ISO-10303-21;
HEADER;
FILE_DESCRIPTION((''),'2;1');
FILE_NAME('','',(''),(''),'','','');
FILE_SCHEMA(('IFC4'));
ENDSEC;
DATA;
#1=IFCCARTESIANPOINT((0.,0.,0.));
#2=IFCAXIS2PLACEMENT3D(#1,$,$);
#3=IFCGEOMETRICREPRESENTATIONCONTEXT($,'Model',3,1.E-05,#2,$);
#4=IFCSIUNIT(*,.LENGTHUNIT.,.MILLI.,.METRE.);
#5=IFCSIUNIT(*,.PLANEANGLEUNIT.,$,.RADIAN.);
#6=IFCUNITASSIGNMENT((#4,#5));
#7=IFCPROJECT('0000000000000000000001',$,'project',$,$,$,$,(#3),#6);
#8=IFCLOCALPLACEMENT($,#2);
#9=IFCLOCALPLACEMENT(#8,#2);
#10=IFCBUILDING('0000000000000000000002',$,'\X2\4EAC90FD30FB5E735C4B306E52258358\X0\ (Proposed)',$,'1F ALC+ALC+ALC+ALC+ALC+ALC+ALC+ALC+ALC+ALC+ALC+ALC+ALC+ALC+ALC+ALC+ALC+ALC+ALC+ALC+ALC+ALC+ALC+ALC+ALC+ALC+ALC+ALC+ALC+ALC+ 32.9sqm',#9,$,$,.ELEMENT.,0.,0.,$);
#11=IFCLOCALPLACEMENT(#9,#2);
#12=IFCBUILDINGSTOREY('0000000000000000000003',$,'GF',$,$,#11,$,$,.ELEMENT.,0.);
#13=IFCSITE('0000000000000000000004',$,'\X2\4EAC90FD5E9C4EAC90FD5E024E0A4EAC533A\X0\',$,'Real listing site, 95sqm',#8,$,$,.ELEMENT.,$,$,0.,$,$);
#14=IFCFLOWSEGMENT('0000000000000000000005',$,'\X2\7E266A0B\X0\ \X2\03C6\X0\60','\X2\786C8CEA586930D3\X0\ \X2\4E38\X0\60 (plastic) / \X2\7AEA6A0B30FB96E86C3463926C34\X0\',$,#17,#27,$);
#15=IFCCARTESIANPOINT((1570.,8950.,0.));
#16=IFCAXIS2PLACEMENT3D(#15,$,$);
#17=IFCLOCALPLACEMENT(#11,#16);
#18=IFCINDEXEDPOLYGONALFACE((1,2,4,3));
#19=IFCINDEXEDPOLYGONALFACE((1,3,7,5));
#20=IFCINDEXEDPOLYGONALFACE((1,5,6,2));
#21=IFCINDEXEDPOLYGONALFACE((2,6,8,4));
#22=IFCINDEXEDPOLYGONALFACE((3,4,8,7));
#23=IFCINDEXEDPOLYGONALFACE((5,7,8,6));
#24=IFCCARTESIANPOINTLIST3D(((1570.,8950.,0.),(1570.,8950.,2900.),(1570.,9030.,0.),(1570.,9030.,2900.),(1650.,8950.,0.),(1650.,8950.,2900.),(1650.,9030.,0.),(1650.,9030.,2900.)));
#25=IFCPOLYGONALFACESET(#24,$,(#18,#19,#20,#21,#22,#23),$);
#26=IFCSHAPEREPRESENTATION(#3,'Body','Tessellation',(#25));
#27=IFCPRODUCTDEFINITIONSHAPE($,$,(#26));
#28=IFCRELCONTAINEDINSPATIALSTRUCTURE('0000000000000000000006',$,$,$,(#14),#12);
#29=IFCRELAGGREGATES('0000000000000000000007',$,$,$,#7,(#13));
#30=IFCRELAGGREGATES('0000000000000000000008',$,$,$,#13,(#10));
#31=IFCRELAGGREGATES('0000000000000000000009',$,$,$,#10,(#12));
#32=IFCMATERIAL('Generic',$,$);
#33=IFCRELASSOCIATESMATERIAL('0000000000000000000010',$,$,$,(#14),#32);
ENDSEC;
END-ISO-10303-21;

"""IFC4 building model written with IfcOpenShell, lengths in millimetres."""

from ifc_helpers import new_model, si_unit, frame, frame_2d, origin, place, context, project, spatial, rectangle, extrude, material, element, save


model = new_model("IFC4")

# Units and contexts
model_context = context("Model", 3, precision=1e-05, world=origin())
ifc_project = project(units=[si_unit("LENGTHUNIT", "METRE", prefix="MILLI"), si_unit("PLANEANGLEUNIT", "RADIAN")], contexts=[model_context])

# Site, building, storey
site_placement = place(None, origin())
site = spatial("IfcSite", under=ifc_project, at=site_placement, Name="京都府京都市上京区", ObjectType="Real listing site, 95sqm", CompositionType="ELEMENT", RefElevation=0.0)
building_placement = place(site_placement, origin())
building = spatial("IfcBuilding", under=site, at=building_placement, Name="京都・平屋の別荘 (Proposed)", ObjectType="1F ALC+ALC+ALC+ALC+ALC+ALC+ALC+ALC+ALC+ALC+ALC+ALC+ALC+ALC+ALC+ALC+ALC+ALC+ALC+ALC+ALC+ALC+ALC+ALC+ALC+ALC+ALC+ALC+ALC+ALC+ 32.9sqm", CompositionType="ELEMENT", ElevationOfRefHeight=0.0, ElevationOfTerrain=0.0)
storey_placement = place(building_placement, origin())
storey = spatial("IfcBuildingStorey", under=building, at=storey_placement, Name="GF", CompositionType="ELEMENT", Elevation=0.0)

# Shared definitions
ifc_material_1 = material(Name="Generic")

# Flow segment
flow_segment_1_placement = place(storey_placement, frame((1570.0, 8950.0, 0.0)))
element("IfcFlowSegment", 1, at=flow_segment_1_placement, inside=storey, material=ifc_material_1, Name="縦樋 φ60", Description="硬質塩ビ 丸60 (plastic) / 竪樋・雨水排水", context=model_context, shape_type="SweptSolid", body=[
    extrude(rectangle(XDim=80.0, YDim=80.0, at=frame_2d((40.0, 40.0))), frame((1570.0, 8950.0, 0.0)), (0.0, 0.0, 1.0), 2900.0),
])

save(model, "model.ifc")
